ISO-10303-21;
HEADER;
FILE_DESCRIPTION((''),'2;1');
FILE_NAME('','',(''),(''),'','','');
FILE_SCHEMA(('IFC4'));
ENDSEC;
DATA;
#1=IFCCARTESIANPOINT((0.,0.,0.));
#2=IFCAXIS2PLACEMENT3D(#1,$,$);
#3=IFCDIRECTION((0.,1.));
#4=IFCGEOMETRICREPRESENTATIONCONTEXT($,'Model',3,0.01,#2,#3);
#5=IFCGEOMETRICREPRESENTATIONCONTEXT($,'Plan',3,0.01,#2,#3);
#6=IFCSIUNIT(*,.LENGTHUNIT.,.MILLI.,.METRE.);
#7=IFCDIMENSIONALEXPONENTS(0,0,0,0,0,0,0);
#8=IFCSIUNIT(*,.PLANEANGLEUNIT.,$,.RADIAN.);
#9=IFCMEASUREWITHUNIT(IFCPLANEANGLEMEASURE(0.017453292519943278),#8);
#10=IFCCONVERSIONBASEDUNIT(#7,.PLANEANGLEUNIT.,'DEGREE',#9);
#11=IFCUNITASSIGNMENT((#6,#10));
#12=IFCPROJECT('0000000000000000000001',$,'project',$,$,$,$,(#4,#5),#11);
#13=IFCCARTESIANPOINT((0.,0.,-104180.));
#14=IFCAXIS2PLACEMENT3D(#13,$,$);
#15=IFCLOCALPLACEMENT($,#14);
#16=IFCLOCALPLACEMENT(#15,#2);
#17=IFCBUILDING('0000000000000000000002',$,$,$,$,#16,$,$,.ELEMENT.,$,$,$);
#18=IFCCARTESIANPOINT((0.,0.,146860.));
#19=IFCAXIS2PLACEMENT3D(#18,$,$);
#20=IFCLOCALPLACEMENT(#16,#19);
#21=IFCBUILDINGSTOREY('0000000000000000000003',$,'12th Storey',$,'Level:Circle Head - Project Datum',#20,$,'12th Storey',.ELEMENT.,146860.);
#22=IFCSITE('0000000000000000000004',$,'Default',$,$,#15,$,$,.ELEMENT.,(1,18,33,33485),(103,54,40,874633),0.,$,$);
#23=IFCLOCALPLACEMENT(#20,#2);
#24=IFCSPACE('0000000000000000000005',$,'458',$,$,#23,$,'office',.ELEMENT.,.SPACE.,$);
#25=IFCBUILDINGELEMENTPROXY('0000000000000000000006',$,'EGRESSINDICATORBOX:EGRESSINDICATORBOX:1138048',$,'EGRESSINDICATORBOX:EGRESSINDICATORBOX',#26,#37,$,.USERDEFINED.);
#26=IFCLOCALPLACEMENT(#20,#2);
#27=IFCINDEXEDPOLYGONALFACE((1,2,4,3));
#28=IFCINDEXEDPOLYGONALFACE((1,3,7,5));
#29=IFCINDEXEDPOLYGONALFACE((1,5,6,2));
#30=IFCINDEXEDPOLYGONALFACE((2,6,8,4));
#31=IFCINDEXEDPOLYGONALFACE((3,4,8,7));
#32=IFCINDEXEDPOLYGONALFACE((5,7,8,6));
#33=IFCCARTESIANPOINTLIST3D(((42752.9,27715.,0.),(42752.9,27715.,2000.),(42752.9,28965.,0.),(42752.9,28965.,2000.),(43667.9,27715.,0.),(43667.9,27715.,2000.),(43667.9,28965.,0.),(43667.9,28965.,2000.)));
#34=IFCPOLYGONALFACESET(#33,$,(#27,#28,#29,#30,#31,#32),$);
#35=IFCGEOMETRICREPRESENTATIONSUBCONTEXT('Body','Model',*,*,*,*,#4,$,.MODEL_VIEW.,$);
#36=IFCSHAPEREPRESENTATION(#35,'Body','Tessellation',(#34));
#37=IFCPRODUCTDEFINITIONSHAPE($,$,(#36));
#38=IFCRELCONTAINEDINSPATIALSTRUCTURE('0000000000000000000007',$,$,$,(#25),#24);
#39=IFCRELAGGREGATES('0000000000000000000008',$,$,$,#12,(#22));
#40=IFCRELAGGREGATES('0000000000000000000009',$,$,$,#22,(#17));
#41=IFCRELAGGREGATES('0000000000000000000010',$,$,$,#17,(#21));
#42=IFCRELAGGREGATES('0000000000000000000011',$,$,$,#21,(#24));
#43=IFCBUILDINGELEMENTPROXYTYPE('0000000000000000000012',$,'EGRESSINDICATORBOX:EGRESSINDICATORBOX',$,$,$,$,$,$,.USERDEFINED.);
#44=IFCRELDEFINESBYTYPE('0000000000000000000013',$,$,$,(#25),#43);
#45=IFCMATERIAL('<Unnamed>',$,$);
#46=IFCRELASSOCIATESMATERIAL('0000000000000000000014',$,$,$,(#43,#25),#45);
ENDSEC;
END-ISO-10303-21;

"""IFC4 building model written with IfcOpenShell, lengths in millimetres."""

from ifc_helpers import new_model, entity, si_unit, converted_unit, direction, frame, origin, place, context, subcontext, project, spatial, indexed_curve, outline, extrude, source, transform, mapped, material, type_object, type_shapes, element, save


model = new_model("IFC4")

# Units and contexts
model_context = context("Model", 3, precision=0.01, world=origin(), true_north=direction((0.0, 1.0)))
plan_context = context("Plan", 3, precision=0.01, world=origin(), true_north=direction((0.0, 1.0)))
body_context = subcontext(model_context, "Body", "Model", "MODEL_VIEW")
ifc_project = project(units=[si_unit("LENGTHUNIT", "METRE", prefix="MILLI"), converted_unit("PLANEANGLEUNIT", "DEGREE", entity("IfcPlaneAngleMeasure", 0.017453292519943278), si_unit("PLANEANGLEUNIT", "RADIAN"), dimensions=[0, 0, 0, 0, 0, 0, 0])], contexts=[model_context, plan_context])

# Site, building, storey
site_placement = place(None, frame((0.0, 0.0, -104180.0)))
site = spatial("IfcSite", under=ifc_project, at=site_placement, Name="Default", CompositionType="ELEMENT", RefLatitude=(1, 18, 33, 33485), RefLongitude=(103, 54, 40, 874633), RefElevation=0.0)
building_placement = place(site_placement, origin())
building = spatial("IfcBuilding", under=site, at=building_placement, CompositionType="ELEMENT")
storey_placement = place(building_placement, frame((0.0, 0.0, 146860.0)))
storey = spatial("IfcBuildingStorey", under=building, at=storey_placement, Name="12th Storey", ObjectType="Level:Circle Head - Project Datum", LongName="12th Storey", CompositionType="ELEMENT", Elevation=146860.0)

# Shared definitions
ifc_material_1 = material(Name="<Unnamed>")

# Shared definitions
space_1_placement = place(storey_placement, origin())
space_1 = spatial("IfcSpace", under=storey, at=space_1_placement, Name="458", LongName="office", CompositionType="ELEMENT", PredefinedType="SPACE")

# Building element proxy
building_element_proxy_type_1 = type_object("IfcBuildingElementProxyType", Name="EGRESSINDICATORBOX:EGRESSINDICATORBOX", PredefinedType="USERDEFINED", material=ifc_material_1)
shared_shape_1 = source(origin(), body_context, "Body", "SweptSolid", [
    extrude(outline(indexed_curve([(-625.0, -457.5), (625.0, -457.5), (625.0, 457.5), (-625.0, 457.5), (-625.0, -457.5)], self_intersect=False)), frame((0.0, 0.0, 0.0), z_axis=(0.0, 0.0, 1.0), x_axis=(0.0, 1.0, 0.0)), (0.0, 0.0, 1.0), 2000.0),
])
type_shapes(building_element_proxy_type_1, [shared_shape_1])
proxy_1_placement = place(space_1_placement, frame((43210.4, 28340.0, 0.0), z_axis=(0.0, 0.0, 1.0), x_axis=(-1.0, 0.0, 0.0)))
element("IfcBuildingElementProxy", 1, at=proxy_1_placement, inside=space_1, type_object=building_element_proxy_type_1, material=ifc_material_1, Name="EGRESSINDICATORBOX:EGRESSINDICATORBOX:1138048", ObjectType="EGRESSINDICATORBOX:EGRESSINDICATORBOX", PredefinedType="USERDEFINED", context=body_context, shape_type="MappedRepresentation", body=[
    mapped(shared_shape_1, transform((0.0, 0.0, 0.0), scale=1.0)),
])

save(model, "model.ifc")
